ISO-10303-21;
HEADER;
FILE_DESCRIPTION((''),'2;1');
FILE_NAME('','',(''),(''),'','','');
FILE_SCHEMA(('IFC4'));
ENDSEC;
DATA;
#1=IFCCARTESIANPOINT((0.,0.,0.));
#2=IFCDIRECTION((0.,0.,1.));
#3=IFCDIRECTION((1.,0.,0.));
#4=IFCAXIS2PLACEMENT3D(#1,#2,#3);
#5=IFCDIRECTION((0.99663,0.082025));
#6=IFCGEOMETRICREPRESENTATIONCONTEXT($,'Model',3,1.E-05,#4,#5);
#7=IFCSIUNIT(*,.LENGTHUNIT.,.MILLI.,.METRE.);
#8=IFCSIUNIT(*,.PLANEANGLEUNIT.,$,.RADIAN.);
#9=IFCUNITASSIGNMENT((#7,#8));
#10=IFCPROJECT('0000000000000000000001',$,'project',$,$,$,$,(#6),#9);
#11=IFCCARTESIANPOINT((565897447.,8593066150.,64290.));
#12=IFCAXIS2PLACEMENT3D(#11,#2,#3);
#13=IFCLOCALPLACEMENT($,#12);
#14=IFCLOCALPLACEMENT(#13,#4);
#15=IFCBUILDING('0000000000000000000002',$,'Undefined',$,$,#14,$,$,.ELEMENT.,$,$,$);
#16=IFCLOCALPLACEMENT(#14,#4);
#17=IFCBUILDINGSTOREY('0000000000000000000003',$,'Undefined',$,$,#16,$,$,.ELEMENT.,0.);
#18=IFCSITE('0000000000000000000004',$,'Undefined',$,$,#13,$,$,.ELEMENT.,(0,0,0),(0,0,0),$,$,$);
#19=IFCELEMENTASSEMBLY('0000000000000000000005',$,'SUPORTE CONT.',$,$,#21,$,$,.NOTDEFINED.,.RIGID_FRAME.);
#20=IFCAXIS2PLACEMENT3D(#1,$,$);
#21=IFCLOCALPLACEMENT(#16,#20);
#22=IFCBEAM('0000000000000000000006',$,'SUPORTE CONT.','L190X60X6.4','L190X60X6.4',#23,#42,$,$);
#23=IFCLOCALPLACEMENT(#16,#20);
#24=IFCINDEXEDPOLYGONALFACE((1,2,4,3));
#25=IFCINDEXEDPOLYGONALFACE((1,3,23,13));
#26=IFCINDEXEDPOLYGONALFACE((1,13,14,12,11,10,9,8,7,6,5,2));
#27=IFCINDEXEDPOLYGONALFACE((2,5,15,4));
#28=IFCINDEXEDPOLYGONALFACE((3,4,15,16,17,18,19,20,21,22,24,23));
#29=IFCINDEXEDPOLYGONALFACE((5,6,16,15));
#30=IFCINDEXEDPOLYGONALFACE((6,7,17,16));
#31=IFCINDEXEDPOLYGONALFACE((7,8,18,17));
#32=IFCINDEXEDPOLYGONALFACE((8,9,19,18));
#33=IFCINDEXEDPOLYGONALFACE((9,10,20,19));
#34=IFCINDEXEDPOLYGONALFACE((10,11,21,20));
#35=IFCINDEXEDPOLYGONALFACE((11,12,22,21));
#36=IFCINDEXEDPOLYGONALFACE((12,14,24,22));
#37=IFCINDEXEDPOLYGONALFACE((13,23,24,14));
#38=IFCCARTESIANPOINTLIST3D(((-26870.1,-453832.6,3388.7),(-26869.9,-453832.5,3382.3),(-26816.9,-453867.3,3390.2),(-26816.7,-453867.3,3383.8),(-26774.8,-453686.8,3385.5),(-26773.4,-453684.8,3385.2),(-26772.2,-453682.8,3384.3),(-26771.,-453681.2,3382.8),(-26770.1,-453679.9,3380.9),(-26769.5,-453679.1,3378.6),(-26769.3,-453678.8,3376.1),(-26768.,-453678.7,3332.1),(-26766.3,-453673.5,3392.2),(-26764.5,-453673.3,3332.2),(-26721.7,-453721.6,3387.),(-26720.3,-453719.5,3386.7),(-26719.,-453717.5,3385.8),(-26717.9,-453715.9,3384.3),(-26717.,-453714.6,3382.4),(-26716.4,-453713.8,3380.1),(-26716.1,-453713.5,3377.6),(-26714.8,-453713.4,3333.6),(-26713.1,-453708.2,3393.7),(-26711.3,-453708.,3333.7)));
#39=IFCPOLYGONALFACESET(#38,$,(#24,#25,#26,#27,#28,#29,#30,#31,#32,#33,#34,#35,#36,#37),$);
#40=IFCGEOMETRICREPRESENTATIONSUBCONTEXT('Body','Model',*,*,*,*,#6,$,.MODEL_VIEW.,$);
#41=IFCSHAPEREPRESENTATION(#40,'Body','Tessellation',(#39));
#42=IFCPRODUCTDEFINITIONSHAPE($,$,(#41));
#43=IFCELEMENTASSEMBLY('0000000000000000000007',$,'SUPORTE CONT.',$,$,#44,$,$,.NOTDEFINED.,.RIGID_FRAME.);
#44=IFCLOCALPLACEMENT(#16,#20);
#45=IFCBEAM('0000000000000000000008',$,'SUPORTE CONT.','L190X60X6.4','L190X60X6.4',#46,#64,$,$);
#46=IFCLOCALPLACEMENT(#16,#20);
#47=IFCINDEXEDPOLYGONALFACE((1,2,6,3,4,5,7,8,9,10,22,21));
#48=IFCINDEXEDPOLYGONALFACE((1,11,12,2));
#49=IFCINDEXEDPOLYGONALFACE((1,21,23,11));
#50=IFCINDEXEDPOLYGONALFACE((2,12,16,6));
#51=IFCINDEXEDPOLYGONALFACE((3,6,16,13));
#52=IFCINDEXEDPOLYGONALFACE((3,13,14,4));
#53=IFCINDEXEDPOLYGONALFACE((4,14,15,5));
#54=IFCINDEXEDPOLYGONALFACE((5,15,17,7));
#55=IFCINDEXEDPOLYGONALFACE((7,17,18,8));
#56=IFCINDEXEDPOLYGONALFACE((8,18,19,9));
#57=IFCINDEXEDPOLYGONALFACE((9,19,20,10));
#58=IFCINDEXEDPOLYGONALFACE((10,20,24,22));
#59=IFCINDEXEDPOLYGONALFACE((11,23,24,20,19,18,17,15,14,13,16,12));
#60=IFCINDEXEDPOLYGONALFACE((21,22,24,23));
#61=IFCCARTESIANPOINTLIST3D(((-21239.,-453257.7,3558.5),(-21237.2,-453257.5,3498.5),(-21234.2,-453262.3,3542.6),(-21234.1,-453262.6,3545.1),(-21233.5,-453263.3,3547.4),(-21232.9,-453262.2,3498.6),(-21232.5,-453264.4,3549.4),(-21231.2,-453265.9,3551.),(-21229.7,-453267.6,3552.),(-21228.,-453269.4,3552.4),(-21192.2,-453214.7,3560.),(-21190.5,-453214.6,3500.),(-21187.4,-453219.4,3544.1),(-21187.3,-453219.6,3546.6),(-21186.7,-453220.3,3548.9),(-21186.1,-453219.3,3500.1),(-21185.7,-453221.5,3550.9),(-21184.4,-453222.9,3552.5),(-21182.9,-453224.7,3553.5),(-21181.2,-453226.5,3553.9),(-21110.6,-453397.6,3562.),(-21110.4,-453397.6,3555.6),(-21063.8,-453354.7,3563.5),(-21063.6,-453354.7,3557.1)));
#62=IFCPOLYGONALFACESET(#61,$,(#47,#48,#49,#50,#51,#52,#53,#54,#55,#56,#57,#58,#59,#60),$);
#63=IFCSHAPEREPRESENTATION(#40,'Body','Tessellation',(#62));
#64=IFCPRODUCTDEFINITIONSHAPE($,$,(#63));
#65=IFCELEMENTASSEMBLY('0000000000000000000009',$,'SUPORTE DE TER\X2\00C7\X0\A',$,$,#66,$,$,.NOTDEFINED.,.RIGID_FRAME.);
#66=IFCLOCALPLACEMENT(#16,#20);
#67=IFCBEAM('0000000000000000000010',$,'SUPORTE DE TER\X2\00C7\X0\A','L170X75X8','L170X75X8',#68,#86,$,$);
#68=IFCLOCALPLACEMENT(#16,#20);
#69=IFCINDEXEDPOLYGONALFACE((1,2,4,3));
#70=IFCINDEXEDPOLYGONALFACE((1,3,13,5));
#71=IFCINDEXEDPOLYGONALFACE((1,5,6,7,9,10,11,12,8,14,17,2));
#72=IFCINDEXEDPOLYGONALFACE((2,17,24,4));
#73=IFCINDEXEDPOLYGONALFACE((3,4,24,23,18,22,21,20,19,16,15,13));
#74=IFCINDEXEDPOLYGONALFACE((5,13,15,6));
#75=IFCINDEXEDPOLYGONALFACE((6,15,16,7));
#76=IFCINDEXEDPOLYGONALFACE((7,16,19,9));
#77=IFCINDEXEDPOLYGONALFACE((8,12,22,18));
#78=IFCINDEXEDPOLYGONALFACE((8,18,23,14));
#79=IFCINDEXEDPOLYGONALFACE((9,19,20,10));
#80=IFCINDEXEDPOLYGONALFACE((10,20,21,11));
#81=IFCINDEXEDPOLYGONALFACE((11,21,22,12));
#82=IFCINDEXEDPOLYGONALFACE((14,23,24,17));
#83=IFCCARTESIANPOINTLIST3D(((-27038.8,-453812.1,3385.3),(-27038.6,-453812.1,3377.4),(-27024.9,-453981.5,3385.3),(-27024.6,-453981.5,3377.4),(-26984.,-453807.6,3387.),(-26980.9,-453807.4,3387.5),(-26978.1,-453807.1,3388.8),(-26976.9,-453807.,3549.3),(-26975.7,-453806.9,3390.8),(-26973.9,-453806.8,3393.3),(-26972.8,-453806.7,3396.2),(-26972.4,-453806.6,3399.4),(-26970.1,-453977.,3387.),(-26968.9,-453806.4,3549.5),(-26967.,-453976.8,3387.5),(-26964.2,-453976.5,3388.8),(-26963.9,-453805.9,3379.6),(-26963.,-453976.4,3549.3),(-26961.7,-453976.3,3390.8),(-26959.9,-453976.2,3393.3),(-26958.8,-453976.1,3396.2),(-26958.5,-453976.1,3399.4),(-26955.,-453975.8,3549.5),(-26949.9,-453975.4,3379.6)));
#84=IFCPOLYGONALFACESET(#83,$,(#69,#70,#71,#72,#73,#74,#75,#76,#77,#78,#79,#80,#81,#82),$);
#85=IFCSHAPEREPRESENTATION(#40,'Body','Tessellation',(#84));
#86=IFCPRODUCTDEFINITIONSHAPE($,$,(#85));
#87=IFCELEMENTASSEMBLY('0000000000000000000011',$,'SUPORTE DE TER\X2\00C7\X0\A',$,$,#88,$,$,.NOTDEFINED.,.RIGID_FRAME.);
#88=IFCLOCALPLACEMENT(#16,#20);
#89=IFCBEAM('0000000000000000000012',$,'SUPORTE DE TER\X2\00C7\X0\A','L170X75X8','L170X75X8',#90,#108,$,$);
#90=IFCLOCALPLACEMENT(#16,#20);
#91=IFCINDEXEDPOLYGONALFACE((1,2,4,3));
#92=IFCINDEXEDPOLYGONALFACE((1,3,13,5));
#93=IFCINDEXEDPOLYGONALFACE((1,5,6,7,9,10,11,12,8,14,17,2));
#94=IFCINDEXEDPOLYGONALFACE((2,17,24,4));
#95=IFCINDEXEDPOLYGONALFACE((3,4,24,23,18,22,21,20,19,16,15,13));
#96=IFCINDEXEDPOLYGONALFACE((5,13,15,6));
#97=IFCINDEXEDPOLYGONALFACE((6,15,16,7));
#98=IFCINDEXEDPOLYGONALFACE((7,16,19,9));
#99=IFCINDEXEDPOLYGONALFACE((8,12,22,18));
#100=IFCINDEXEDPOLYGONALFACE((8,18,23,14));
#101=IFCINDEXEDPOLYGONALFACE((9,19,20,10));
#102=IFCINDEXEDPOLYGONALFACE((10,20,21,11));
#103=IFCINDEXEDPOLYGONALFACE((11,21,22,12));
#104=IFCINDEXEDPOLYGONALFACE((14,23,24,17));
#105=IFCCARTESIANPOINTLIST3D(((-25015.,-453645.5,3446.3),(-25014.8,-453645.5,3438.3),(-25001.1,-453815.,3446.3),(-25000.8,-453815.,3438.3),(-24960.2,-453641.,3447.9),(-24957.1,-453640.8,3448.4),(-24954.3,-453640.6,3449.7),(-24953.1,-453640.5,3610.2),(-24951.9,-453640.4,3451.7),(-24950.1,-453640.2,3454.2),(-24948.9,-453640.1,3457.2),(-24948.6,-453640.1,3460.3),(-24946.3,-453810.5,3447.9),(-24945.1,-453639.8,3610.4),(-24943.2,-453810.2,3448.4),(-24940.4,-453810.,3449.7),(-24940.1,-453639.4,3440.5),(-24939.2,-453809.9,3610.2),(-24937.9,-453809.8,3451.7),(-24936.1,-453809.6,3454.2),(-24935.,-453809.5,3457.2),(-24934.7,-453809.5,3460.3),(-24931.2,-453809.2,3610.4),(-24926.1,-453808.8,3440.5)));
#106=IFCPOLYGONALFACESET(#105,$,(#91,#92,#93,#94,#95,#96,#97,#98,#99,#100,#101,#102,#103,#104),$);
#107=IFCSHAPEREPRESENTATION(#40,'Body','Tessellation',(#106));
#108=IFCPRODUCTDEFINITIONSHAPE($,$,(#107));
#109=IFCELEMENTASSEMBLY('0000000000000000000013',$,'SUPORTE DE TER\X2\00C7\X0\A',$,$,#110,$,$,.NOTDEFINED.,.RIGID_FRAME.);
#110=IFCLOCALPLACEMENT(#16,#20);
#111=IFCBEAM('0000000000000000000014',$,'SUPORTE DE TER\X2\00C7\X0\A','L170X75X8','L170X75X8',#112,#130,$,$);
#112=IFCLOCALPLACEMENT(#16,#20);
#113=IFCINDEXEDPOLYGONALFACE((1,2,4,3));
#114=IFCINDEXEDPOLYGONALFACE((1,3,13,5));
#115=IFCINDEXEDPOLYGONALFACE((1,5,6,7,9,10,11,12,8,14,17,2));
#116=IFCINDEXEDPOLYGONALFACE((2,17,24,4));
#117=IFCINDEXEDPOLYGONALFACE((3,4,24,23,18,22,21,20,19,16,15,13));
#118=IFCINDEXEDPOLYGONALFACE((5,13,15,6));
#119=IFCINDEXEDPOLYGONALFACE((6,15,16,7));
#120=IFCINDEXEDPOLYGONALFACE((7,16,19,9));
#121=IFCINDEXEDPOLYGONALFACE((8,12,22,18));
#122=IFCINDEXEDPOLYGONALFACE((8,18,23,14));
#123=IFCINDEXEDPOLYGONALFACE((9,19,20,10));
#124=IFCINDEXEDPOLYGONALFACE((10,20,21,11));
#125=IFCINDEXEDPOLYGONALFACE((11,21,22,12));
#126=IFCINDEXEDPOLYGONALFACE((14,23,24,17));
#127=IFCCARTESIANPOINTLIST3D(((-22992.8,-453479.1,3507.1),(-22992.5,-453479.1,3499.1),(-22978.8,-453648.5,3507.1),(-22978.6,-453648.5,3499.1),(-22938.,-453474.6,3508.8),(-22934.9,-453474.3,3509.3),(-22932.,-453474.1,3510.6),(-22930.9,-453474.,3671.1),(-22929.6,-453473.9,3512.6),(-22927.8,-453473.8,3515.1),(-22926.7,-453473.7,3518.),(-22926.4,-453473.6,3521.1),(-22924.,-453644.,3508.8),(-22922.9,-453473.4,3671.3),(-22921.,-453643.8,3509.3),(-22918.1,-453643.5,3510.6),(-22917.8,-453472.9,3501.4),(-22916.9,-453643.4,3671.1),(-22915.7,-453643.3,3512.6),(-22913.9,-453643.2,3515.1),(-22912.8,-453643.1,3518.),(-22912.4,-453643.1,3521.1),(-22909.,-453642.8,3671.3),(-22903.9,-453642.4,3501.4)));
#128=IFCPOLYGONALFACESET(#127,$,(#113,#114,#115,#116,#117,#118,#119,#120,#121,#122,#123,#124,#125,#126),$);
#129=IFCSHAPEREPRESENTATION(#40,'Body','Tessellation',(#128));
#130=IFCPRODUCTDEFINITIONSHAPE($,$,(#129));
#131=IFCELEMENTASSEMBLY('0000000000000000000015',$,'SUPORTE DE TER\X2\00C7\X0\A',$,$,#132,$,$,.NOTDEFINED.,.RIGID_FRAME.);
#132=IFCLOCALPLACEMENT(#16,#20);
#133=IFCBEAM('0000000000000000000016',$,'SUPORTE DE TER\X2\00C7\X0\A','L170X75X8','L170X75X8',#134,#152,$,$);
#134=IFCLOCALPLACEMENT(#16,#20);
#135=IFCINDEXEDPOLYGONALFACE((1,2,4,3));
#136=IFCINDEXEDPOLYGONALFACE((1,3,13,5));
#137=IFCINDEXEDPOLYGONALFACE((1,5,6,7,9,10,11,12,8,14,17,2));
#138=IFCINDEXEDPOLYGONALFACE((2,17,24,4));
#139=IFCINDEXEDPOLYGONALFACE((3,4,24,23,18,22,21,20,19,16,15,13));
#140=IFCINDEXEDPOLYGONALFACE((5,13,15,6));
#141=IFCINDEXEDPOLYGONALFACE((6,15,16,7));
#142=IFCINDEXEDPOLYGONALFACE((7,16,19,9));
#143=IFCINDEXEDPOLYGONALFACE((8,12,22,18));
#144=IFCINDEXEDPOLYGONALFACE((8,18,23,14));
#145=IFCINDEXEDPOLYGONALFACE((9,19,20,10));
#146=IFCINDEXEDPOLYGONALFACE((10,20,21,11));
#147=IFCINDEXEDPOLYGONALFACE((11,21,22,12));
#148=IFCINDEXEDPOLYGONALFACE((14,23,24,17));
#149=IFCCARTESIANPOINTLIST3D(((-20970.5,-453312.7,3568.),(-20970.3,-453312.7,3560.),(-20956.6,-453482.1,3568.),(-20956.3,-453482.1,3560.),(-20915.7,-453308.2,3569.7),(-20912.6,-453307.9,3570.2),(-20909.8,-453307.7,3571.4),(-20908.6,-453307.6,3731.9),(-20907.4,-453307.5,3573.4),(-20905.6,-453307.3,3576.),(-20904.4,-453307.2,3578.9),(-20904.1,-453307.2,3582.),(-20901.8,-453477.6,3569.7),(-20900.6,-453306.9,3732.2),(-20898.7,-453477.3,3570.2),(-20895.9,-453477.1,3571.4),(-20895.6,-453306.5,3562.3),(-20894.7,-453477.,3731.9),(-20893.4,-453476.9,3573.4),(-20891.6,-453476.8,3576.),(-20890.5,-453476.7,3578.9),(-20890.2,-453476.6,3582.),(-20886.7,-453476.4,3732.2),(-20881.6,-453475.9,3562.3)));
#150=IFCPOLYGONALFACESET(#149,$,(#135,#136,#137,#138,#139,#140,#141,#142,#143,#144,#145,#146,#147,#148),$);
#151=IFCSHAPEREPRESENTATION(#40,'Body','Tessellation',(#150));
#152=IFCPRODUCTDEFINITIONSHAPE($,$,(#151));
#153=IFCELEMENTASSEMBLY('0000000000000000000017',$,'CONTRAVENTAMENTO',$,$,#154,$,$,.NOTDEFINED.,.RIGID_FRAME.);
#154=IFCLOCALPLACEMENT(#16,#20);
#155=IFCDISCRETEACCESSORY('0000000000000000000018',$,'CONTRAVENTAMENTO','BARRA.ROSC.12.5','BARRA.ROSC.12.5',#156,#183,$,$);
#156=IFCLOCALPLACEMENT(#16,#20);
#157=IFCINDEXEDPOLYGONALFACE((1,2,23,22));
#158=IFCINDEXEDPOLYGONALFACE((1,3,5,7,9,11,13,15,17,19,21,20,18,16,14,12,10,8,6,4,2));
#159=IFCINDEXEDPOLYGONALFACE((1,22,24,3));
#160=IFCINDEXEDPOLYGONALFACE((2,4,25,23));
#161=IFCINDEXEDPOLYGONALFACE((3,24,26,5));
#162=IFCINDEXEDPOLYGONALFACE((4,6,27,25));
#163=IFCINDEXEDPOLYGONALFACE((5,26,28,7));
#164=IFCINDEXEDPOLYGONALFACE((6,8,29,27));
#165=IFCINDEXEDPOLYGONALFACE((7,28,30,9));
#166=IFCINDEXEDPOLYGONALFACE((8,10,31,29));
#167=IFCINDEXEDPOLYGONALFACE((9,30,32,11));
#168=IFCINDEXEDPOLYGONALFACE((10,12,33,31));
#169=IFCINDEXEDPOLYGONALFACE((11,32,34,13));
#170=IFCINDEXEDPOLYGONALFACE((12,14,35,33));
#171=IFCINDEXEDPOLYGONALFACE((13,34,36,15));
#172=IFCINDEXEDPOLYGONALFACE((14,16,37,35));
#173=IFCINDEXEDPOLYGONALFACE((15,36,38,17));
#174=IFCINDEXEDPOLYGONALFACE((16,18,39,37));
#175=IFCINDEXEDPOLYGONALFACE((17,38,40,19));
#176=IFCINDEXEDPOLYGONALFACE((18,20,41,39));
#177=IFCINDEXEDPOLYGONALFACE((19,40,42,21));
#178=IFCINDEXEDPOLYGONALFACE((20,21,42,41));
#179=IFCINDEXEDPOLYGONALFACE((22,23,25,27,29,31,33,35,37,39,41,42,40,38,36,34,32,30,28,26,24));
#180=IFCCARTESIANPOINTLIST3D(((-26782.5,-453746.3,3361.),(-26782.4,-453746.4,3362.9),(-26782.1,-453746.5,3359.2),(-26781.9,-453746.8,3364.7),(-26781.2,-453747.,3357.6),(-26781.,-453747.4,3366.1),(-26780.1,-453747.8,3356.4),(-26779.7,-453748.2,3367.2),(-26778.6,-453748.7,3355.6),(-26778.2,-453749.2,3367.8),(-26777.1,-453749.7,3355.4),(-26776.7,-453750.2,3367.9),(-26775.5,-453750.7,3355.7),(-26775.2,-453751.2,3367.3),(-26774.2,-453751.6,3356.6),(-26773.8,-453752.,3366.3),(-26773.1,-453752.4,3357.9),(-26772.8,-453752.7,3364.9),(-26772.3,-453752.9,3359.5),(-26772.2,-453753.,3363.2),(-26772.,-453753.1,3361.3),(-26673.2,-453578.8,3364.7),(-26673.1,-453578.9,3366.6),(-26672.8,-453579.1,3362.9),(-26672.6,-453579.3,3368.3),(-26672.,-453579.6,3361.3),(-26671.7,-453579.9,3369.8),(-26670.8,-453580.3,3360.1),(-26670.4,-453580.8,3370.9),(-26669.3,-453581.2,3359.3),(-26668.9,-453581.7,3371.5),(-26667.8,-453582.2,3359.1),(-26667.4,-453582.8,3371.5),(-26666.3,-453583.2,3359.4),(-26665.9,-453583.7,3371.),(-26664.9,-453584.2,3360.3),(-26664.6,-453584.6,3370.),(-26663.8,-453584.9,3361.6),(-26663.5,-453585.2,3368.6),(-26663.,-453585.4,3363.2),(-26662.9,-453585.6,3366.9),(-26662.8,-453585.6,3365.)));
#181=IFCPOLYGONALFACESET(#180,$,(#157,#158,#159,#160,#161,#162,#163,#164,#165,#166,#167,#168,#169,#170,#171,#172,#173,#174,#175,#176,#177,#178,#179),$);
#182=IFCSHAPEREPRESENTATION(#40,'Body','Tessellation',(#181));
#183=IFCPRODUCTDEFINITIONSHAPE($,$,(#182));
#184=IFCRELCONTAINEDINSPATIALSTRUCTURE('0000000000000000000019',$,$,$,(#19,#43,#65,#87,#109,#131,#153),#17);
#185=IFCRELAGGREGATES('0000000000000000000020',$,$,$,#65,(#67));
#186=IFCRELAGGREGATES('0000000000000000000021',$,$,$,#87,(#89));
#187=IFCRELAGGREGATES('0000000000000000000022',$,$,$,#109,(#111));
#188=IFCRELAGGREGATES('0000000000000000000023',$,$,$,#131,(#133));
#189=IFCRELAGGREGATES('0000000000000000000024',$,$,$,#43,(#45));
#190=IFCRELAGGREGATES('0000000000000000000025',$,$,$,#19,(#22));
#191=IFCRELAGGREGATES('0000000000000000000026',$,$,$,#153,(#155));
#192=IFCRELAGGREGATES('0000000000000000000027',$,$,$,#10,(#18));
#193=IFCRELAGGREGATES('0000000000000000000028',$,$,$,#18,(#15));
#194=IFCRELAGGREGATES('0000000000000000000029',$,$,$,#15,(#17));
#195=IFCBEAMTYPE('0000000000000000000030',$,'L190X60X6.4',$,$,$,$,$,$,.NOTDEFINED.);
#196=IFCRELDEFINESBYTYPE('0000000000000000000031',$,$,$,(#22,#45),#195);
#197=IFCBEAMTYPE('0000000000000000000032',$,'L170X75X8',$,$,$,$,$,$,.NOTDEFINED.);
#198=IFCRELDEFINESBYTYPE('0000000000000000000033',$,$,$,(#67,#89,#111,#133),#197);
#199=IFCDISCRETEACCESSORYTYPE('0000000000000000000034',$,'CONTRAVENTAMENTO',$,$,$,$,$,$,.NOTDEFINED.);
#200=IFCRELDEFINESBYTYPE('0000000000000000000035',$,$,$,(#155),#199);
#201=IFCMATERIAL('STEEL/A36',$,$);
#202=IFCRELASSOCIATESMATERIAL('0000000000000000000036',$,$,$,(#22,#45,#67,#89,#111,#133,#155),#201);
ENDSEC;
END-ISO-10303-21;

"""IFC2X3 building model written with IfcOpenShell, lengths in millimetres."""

from ifc_helpers import new_model, si_unit, direction, frame, origin_with_axes, origin_2d_with_axis, place, context, subcontext, project, spatial, circle, l_section, extrude, material, type_object, element, aggregate, save


model = new_model("IFC2X3")

# Units and contexts
model_context = context("Model", 3, precision=1e-05, world=origin_with_axes(), true_north=direction((0.99663, 0.082025)))
body_context = subcontext(model_context, "Body", "Model", "MODEL_VIEW")
ifc_project = project(units=[si_unit("LENGTHUNIT", "METRE", prefix="MILLI"), si_unit("PLANEANGLEUNIT", "RADIAN")], contexts=[model_context])

# Site, building, storey
site_placement = place(None, frame((565897447.0, 8593066150.0, 64290.0), z_axis=(0.0, 0.0, 1.0), x_axis=(1.0, 0.0, 0.0)))
site = spatial("IfcSite", under=ifc_project, at=site_placement, Name="Undefined", CompositionType="ELEMENT", RefLatitude=(0, 0, 0), RefLongitude=(0, 0, 0))
building_placement = place(site_placement, origin_with_axes())
building = spatial("IfcBuilding", under=site, at=building_placement, Name="Undefined", CompositionType="ELEMENT")
storey_placement = place(building_placement, origin_with_axes())
storey = spatial("IfcBuildingStorey", under=building, at=storey_placement, Name="Undefined", CompositionType="ELEMENT", Elevation=0.0)

# Element assemblies, beams
ifc_material_1 = material(Name="STEEL/A36")
beam_type_1 = type_object("IfcBeamType", Name="L190X60X6.4", PredefinedType="NOTDEFINED")
assembly_1_placement = place(storey_placement, origin_with_axes())
assembly_1 = element("IfcElementAssembly", 1, at=assembly_1_placement, inside=storey, Name="SUPORTE CONT.", AssemblyPlace="NOTDEFINED", PredefinedType="RIGID_FRAME")
beam_1_placement = place(assembly_1_placement, frame((-26817.3, -453752.9, 3360.5), z_axis=(-0.546411, -0.837315, -0.018398), x_axis=(0.836984, -0.546715, 0.02368)))
beam_1 = element("IfcBeam", 2, at=beam_1_placement, type_object=beam_type_1, material=ifc_material_1, Name="SUPORTE CONT.", Description="L190X60X6.4", ObjectType="L190X60X6.4", context=body_context, shape_type="SweptSolid", body=[
    extrude(l_section(Depth=190.0, Width=60.0, Thickness=6.4, FilletRadius=9.6, at=origin_2d_with_axis()), frame((63.5, 0.0, 0.0), z_axis=(-1.0, 0.0, 0.0), x_axis=(0.0, -1.0, 0.0)), (0.0, 0.0, 1.0), 63.5),
])
assembly_2_placement = place(storey_placement, origin_with_axes())
assembly_2 = element("IfcElementAssembly", 3, at=assembly_2_placement, inside=storey, Name="SUPORTE CONT.", AssemblyPlace="NOTDEFINED", PredefinedType="RIGID_FRAME")
beam_2_placement = place(assembly_2_placement, frame((-21173.9, -453327.6, 3530.2), z_axis=(0.675958, -0.736711, 0.018398), x_axis=(0.736334, 0.676203, 0.02368)))
beam_2 = element("IfcBeam", 4, at=beam_2_placement, type_object=beam_type_1, material=ifc_material_1, Name="SUPORTE CONT.", Description="L190X60X6.4", ObjectType="L190X60X6.4", context=body_context, shape_type="SweptSolid", body=[
    extrude(l_section(Depth=190.0, Width=60.0, Thickness=6.4, FilletRadius=9.6, at=origin_2d_with_axis()), frame((63.5, 0.0, 0.0), z_axis=(-1.0, 0.0, 0.0), x_axis=(0.0, -1.0, 0.0)), (0.0, 0.0, 1.0), 63.5),
])
assembly_3_placement = place(storey_placement, origin_with_axes())
assembly_3 = element("IfcElementAssembly", 5, at=assembly_3_placement, inside=storey, Name="SUPORTE DE TERÇA", AssemblyPlace="NOTDEFINED", PredefinedType="RIGID_FRAME")
beam_type_2 = type_object("IfcBeamType", Name="L170X75X8", PredefinedType="NOTDEFINED")
beam_3_placement = place(assembly_3_placement, frame((-27003.8, -453809.2, 3463.4), z_axis=(-0.029885, -0.00246, 0.99955), x_axis=(0.082025, -0.99663, 0.0)))
beam_3 = element("IfcBeam", 6, at=beam_3_placement, type_object=beam_type_2, material=ifc_material_1, Name="SUPORTE DE TERÇA", Description="L170X75X8", ObjectType="L170X75X8", context=body_context, shape_type="SweptSolid", body=[
    extrude(l_section(Depth=170.0, Width=75.0, Thickness=8.0, FilletRadius=12.0, at=origin_2d_with_axis()), frame((170.0, 0.0, 0.0), z_axis=(-1.0, 0.0, 0.0), x_axis=(0.0, -1.0, 0.0)), (0.0, 0.0, 1.0), 170.0),
])
aggregate(assembly_3, [beam_3])
assembly_4_placement = place(storey_placement, origin_with_axes())
assembly_4 = element("IfcElementAssembly", 7, at=assembly_4_placement, inside=storey, Name="SUPORTE DE TERÇA", AssemblyPlace="NOTDEFINED", PredefinedType="RIGID_FRAME")
beam_4_placement = place(assembly_4_placement, frame((-24980.0, -453642.7, 3524.4), z_axis=(-0.029885, -0.00246, 0.99955), x_axis=(0.082025, -0.99663, 0.0)))
beam_4 = element("IfcBeam", 8, at=beam_4_placement, type_object=beam_type_2, material=ifc_material_1, Name="SUPORTE DE TERÇA", Description="L170X75X8", ObjectType="L170X75X8", context=body_context, shape_type="SweptSolid", body=[
    extrude(l_section(Depth=170.0, Width=75.0, Thickness=8.0, FilletRadius=12.0, at=origin_2d_with_axis()), frame((170.0, 0.0, 0.0), z_axis=(-1.0, 0.0, 0.0), x_axis=(0.0, -1.0, 0.0)), (0.0, 0.0, 1.0), 170.0),
])
aggregate(assembly_4, [beam_4])
assembly_5_placement = place(storey_placement, origin_with_axes())
assembly_5 = element("IfcElementAssembly", 9, at=assembly_5_placement, inside=storey, Name="SUPORTE DE TERÇA", AssemblyPlace="NOTDEFINED", PredefinedType="RIGID_FRAME")
beam_5_placement = place(assembly_5_placement, frame((-22957.7, -453476.2, 3585.2), z_axis=(-0.029885, -0.00246, 0.99955), x_axis=(0.082025, -0.99663, 0.0)))
beam_5 = element("IfcBeam", 10, at=beam_5_placement, type_object=beam_type_2, material=ifc_material_1, Name="SUPORTE DE TERÇA", Description="L170X75X8", ObjectType="L170X75X8", context=body_context, shape_type="SweptSolid", body=[
    extrude(l_section(Depth=170.0, Width=75.0, Thickness=8.0, FilletRadius=12.0, at=origin_2d_with_axis()), frame((170.0, 0.0, 0.0), z_axis=(-1.0, 0.0, 0.0), x_axis=(0.0, -1.0, 0.0)), (0.0, 0.0, 1.0), 170.0),
])
aggregate(assembly_5, [beam_5])
assembly_6_placement = place(storey_placement, origin_with_axes())
assembly_6 = element("IfcElementAssembly", 11, at=assembly_6_placement, inside=storey, Name="SUPORTE DE TERÇA", AssemblyPlace="NOTDEFINED", PredefinedType="RIGID_FRAME")
beam_6_placement = place(assembly_6_placement, frame((-20935.5, -453309.8, 3646.1), z_axis=(-0.029885, -0.00246, 0.99955), x_axis=(0.082025, -0.99663, 0.0)))
beam_6 = element("IfcBeam", 12, at=beam_6_placement, type_object=beam_type_2, material=ifc_material_1, Name="SUPORTE DE TERÇA", Description="L170X75X8", ObjectType="L170X75X8", context=body_context, shape_type="SweptSolid", body=[
    extrude(l_section(Depth=170.0, Width=75.0, Thickness=8.0, FilletRadius=12.0, at=origin_2d_with_axis()), frame((170.0, 0.0, 0.0), z_axis=(-1.0, 0.0, 0.0), x_axis=(0.0, -1.0, 0.0)), (0.0, 0.0, 1.0), 170.0),
])
aggregate(assembly_6, [beam_6])

aggregate(assembly_2, [beam_2])
aggregate(assembly_1, [beam_1])

# Element assembly, discrete accessory
assembly_7_placement = place(storey_placement, origin_with_axes())
assembly_7 = element("IfcElementAssembly", 13, at=assembly_7_placement, inside=storey, Name="CONTRAVENTAMENTO", AssemblyPlace="NOTDEFINED", PredefinedType="RIGID_FRAME")
discrete_accessory_type_1 = type_object("IfcDiscreteAccessoryType", Name="CONTRAVENTAMENTO")
discrete_accessory_1_placement = place(assembly_7_placement, frame((-26777.3, -453749.7, 3361.7), z_axis=(0.836984, -0.546715, 0.02368), x_axis=(0.546411, 0.837315, 0.018398)))
discrete_accessory_1 = element("IfcDiscreteAccessory", 14, at=discrete_accessory_1_placement, type_object=discrete_accessory_type_1, material=ifc_material_1, Name="CONTRAVENTAMENTO", Description="BARRA.ROSC.12.5", ObjectType="BARRA.ROSC.12.5", context=body_context, shape_type="SweptSolid", body=[
    extrude(circle(Radius=6.2, at=origin_2d_with_axis()), frame((200.0, 0.0, 0.0), z_axis=(-1.0, 0.0, 0.0), x_axis=(0.0, -1.0, 0.0)), (0.0, 0.0, 1.0), 200.0),
])

aggregate(assembly_7, [discrete_accessory_1])

save(model, "model.ifc")
